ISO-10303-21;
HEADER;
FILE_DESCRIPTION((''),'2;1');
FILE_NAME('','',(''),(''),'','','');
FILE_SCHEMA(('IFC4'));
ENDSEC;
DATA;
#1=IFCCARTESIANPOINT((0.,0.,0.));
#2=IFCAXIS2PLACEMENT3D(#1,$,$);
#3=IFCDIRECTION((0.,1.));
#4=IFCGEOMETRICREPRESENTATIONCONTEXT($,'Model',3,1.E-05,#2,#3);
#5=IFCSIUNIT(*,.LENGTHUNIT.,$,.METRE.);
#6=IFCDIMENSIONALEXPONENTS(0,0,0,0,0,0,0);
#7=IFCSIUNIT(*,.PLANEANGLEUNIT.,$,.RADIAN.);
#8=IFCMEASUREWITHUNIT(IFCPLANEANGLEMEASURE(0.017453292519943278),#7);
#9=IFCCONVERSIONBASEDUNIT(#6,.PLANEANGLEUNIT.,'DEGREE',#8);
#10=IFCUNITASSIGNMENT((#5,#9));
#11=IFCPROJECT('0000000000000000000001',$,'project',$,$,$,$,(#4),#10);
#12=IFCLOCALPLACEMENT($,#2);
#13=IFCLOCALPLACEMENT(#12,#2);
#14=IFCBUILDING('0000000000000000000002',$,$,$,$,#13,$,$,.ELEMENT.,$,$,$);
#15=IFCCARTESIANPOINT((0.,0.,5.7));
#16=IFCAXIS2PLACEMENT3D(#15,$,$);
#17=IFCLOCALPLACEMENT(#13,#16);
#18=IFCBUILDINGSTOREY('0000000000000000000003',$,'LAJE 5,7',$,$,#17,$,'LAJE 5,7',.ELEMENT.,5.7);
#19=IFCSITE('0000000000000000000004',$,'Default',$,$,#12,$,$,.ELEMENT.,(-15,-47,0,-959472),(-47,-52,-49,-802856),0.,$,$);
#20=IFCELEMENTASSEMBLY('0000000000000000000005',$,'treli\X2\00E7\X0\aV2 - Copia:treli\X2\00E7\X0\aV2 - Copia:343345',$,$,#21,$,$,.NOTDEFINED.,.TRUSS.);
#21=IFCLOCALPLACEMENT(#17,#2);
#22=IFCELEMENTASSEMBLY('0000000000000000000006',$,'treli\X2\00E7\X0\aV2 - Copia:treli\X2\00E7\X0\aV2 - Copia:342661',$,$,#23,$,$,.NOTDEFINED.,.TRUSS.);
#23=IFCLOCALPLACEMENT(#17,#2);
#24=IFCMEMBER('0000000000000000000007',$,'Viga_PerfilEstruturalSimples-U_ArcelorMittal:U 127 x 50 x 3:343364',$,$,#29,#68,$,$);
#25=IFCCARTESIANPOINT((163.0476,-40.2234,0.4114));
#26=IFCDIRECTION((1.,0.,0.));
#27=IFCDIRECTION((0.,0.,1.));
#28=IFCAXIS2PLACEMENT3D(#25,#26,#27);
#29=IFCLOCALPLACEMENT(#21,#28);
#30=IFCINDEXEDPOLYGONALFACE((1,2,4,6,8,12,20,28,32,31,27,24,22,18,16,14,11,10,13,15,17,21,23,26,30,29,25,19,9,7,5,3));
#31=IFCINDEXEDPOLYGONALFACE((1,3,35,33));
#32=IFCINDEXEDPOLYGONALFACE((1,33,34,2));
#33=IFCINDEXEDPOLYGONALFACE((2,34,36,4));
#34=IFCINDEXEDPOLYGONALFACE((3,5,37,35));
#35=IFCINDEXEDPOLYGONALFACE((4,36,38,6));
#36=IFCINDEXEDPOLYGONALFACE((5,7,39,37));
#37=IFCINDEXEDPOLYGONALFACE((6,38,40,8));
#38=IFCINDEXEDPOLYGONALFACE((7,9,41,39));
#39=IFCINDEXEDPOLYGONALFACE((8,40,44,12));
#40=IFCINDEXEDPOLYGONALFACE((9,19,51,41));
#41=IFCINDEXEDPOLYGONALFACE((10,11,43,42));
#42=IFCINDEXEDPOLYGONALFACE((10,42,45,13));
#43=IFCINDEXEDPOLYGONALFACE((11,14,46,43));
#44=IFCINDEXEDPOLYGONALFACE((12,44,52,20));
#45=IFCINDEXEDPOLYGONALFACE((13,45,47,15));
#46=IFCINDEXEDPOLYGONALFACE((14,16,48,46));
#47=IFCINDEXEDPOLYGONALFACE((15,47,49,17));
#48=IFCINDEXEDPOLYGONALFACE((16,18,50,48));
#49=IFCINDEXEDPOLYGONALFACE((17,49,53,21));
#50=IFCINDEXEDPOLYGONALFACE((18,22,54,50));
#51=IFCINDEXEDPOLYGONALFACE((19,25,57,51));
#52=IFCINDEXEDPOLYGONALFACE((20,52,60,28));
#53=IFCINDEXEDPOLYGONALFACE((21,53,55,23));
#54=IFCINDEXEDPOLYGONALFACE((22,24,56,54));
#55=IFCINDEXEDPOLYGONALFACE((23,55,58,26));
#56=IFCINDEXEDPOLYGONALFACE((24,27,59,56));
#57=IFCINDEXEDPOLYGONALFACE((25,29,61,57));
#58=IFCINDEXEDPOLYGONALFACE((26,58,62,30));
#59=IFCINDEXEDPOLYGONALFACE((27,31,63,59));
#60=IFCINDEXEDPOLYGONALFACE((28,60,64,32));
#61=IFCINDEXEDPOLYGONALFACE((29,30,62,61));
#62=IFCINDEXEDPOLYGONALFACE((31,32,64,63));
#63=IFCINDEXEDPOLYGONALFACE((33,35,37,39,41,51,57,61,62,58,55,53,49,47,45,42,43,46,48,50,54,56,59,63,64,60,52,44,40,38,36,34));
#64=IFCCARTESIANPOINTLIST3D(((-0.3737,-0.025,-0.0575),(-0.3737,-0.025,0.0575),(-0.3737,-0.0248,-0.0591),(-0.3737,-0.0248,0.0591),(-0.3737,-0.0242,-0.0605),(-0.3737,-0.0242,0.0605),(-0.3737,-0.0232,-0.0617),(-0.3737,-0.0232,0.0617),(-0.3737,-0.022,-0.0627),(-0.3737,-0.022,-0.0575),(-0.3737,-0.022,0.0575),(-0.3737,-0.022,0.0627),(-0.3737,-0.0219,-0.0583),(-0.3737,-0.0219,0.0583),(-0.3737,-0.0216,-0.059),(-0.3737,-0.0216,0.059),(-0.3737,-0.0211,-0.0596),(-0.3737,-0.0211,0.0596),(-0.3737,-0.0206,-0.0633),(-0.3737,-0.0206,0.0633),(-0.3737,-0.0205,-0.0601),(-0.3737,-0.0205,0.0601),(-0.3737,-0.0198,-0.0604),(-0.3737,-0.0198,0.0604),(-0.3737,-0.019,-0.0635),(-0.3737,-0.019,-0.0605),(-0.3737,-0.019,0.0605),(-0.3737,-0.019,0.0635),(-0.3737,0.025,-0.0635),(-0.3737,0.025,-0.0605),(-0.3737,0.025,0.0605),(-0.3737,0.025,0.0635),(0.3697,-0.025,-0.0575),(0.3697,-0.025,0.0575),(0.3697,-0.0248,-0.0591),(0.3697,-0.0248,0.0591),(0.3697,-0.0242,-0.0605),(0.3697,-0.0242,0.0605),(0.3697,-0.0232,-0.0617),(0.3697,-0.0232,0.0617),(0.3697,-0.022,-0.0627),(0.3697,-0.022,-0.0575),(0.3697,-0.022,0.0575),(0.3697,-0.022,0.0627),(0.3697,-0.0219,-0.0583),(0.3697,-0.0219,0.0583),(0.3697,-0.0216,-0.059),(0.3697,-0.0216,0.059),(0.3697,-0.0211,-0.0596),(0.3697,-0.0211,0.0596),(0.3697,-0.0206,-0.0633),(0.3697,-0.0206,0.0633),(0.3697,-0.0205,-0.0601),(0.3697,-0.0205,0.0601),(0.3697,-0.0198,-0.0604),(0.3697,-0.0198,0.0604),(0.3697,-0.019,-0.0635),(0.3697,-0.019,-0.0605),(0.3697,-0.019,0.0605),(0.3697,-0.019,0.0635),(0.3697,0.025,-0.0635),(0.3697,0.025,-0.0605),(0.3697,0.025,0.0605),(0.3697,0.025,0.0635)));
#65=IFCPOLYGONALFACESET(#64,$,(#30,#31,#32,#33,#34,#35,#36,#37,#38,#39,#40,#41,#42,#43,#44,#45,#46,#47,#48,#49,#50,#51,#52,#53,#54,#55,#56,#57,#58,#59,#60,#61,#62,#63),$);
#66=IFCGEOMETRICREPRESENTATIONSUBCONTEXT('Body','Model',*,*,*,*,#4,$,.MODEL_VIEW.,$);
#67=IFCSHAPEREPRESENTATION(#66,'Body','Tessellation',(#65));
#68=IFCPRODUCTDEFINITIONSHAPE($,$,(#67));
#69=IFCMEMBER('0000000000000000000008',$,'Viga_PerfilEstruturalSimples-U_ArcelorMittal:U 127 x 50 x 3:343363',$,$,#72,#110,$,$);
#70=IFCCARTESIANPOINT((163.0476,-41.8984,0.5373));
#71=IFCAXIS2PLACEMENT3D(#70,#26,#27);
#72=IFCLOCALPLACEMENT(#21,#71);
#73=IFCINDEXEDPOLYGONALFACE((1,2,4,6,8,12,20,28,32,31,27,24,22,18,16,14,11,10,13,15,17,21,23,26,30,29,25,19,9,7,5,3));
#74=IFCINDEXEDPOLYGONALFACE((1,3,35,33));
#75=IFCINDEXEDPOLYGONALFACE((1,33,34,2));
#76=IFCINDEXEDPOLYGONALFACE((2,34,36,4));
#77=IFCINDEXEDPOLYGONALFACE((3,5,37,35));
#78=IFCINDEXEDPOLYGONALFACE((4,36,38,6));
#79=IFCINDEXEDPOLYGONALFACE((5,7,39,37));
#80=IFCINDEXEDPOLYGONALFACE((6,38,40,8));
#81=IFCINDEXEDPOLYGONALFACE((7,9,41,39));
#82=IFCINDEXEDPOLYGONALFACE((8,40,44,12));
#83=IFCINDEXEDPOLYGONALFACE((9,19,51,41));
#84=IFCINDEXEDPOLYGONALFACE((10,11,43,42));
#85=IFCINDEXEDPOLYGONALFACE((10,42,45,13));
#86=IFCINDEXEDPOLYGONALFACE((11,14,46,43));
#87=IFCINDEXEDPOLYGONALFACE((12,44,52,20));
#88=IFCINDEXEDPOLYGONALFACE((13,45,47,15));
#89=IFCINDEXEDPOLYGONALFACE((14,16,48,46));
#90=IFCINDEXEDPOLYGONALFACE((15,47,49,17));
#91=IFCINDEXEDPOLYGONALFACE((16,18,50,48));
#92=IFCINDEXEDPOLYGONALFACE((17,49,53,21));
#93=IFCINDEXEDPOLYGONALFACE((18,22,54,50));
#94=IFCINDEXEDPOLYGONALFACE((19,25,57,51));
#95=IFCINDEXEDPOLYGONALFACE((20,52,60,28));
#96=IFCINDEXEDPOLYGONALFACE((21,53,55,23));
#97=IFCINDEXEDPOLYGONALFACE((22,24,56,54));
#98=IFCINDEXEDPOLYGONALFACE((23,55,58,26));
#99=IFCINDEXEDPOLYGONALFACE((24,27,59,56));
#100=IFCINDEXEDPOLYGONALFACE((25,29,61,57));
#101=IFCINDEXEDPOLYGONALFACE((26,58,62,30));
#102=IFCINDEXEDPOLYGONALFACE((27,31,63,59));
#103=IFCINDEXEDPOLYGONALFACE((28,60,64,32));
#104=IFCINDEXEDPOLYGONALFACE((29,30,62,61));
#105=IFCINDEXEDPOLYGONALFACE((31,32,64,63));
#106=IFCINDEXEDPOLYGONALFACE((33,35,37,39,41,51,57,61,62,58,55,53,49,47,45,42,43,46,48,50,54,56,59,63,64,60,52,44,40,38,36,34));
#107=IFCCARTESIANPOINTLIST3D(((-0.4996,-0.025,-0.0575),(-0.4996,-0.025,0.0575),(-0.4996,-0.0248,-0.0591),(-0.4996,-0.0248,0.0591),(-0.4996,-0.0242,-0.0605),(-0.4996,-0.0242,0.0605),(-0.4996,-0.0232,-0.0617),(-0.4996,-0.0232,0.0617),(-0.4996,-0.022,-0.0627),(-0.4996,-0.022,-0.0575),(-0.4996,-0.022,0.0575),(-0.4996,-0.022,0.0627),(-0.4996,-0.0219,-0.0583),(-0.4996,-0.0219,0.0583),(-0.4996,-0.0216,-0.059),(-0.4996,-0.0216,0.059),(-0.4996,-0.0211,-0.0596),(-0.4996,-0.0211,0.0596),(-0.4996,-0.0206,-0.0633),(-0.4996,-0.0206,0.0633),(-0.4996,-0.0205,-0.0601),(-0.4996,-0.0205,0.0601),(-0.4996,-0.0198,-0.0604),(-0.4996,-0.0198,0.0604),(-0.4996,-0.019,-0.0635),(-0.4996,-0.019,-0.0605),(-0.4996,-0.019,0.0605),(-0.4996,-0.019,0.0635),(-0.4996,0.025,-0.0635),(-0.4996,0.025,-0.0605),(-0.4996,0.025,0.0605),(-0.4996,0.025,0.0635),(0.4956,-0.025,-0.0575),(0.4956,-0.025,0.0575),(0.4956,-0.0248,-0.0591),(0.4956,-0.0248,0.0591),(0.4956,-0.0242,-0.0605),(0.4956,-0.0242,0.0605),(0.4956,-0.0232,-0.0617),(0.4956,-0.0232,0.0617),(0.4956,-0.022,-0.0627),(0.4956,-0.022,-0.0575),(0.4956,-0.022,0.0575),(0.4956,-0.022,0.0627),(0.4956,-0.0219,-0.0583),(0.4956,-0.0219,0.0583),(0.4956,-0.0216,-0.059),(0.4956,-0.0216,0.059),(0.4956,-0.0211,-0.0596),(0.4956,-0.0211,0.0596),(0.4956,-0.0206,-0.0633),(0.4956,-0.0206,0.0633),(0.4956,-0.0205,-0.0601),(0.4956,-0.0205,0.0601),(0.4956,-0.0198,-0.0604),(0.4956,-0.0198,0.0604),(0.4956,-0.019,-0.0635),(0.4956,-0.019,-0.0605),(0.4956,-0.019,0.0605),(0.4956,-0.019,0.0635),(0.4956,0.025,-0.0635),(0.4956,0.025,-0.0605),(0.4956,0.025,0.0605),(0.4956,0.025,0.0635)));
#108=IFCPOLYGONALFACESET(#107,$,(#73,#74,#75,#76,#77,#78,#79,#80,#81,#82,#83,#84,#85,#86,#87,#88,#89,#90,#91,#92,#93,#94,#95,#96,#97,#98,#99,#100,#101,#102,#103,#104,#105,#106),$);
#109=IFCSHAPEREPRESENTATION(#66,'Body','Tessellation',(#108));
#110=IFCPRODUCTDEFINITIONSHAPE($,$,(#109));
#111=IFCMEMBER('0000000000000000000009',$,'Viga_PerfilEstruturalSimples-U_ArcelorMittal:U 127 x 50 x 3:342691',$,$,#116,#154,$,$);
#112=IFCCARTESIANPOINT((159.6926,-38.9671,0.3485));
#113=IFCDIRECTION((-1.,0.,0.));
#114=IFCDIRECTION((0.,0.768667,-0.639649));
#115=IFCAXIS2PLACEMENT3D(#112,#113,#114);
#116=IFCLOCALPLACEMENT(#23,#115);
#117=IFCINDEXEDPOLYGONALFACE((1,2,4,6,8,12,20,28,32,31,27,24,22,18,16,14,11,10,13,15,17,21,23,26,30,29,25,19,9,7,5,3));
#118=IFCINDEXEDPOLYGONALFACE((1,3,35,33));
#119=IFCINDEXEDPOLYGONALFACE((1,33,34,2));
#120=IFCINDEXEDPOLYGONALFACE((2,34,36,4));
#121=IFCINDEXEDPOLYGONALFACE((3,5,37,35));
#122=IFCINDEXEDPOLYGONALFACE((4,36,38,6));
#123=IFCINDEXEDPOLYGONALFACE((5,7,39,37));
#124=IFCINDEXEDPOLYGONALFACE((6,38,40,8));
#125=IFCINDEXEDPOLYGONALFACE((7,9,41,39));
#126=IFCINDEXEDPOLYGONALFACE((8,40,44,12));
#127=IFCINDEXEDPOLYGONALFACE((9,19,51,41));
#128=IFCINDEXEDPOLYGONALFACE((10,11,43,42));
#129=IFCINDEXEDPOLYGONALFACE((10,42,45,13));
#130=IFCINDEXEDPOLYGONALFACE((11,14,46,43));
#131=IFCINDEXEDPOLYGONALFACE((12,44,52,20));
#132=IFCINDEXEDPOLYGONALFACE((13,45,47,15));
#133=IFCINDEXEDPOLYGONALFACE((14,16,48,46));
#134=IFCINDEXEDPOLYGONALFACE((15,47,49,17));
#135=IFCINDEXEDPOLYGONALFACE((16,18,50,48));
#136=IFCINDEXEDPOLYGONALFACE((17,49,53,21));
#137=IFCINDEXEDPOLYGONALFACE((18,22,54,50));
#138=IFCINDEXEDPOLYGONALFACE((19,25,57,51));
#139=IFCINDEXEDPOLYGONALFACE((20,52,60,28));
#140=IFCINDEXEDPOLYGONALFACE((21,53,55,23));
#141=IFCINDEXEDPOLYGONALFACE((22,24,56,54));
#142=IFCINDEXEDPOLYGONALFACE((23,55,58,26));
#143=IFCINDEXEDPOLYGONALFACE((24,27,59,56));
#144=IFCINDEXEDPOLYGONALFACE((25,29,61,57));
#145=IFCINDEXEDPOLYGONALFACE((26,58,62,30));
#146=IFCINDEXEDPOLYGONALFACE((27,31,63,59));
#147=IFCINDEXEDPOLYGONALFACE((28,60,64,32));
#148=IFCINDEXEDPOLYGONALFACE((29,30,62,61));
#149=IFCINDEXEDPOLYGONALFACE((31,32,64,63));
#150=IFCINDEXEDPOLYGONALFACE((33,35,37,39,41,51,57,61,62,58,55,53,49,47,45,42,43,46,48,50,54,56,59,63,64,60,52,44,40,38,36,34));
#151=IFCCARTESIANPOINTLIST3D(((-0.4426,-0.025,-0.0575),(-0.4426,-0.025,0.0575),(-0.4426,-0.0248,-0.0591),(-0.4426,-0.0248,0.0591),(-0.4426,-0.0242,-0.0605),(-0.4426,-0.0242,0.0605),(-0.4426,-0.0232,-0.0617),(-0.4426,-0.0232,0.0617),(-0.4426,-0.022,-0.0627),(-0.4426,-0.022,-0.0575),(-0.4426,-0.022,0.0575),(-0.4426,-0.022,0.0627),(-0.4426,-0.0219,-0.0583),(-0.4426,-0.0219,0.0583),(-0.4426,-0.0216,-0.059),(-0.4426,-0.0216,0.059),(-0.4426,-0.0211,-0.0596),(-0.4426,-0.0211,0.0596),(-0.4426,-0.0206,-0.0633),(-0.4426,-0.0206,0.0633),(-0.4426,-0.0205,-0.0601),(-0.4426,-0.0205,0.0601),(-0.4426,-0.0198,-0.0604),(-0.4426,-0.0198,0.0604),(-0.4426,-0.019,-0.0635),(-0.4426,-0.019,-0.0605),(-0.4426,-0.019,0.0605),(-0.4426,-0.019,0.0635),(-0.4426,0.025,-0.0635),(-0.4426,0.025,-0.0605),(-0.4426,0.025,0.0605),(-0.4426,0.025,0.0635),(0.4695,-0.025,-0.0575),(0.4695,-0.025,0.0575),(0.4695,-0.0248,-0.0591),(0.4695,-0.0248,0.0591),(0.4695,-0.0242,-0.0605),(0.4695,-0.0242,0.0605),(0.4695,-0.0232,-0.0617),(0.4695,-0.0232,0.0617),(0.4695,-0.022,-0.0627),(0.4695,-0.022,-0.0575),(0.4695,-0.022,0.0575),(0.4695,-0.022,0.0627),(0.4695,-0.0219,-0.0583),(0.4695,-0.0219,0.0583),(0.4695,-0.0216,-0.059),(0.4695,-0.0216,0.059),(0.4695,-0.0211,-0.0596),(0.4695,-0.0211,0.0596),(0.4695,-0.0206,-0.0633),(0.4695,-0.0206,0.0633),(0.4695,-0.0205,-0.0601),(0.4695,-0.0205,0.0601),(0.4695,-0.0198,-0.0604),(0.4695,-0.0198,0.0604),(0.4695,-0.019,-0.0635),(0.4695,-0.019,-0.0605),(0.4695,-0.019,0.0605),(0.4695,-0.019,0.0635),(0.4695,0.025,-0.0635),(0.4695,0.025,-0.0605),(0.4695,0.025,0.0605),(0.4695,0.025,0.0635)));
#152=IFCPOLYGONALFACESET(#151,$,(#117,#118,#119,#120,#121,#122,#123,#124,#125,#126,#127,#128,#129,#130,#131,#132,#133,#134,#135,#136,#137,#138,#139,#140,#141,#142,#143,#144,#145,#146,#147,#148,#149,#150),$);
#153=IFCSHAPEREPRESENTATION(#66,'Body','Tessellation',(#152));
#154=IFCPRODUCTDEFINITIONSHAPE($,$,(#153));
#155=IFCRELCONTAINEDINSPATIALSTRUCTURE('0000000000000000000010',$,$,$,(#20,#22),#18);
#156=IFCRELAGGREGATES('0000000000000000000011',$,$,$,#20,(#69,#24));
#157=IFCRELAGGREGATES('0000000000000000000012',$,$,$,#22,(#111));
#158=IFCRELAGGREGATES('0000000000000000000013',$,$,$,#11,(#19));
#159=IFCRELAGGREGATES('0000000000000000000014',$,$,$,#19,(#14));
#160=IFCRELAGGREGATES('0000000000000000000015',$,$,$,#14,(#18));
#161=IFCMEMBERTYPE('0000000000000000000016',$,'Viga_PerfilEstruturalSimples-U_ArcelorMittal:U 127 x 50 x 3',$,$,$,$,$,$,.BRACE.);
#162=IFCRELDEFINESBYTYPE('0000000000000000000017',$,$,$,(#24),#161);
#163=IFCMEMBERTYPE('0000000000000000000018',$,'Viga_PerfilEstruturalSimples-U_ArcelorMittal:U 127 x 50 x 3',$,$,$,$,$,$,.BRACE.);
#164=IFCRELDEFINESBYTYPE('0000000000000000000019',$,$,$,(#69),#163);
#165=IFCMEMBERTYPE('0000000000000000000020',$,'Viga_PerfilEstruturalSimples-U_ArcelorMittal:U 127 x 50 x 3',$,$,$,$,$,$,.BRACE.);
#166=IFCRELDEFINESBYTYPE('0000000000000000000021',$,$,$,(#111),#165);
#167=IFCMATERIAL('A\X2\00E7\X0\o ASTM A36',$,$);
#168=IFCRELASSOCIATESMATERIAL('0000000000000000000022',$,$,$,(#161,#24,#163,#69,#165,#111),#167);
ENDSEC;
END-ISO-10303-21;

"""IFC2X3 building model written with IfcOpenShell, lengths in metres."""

from ifc_helpers import new_model, entity, si_unit, converted_unit, direction, frame, frame_2d, origin, place, context, subcontext, project, spatial, polyline, circle_curve, parameter, trimmed, segment, composite_curve, outline, extrude, source, transform, mapped, material, type_object, type_shapes, element, aggregate, save


model = new_model("IFC2X3")

# Units and contexts
model_context = context("Model", 3, precision=1e-05, world=origin(), true_north=direction((0.0, 1.0)))
body_context = subcontext(model_context, "Body", "Model", "MODEL_VIEW")
ifc_project = project(units=[si_unit("LENGTHUNIT", "METRE"), converted_unit("PLANEANGLEUNIT", "DEGREE", entity("IfcPlaneAngleMeasure", 0.017453292519943278), si_unit("PLANEANGLEUNIT", "RADIAN"), dimensions=[0, 0, 0, 0, 0, 0, 0])], contexts=[model_context])

# Site, building, storey
site_placement = place(None, origin())
site = spatial("IfcSite", under=ifc_project, at=site_placement, Name="Default", CompositionType="ELEMENT", RefLatitude=(-15, -47, 0, -959472), RefLongitude=(-47, -52, -49, -802856), RefElevation=0.0)
building_placement = place(site_placement, origin())
building = spatial("IfcBuilding", under=site, at=building_placement, CompositionType="ELEMENT")
storey_placement = place(building_placement, frame((0.0, 0.0, 5.7)))
storey = spatial("IfcBuildingStorey", under=building, at=storey_placement, Name="LAJE 5,7", LongName="LAJE 5,7", CompositionType="ELEMENT", Elevation=5.7)

# Element assemblies
assembly_1_placement = place(storey_placement, origin())
assembly_1 = element("IfcElementAssembly", 1, at=assembly_1_placement, inside=storey, Name="treliçaV2 - Copia:treliçaV2 - Copia:343345", AssemblyPlace="NOTDEFINED", PredefinedType="TRUSS")
ifc_material = material(Name="Aço ASTM A36")
assembly_2_placement = place(storey_placement, origin())
assembly_2 = element("IfcElementAssembly", 2, at=assembly_2_placement, inside=storey, Name="treliçaV2 - Copia:treliçaV2 - Copia:342661", AssemblyPlace="NOTDEFINED", PredefinedType="TRUSS")

# Members
member_type_1 = type_object("IfcMemberType", Name="Viga_PerfilEstruturalSimples-U_ArcelorMittal:U 127 x 50 x 3", PredefinedType="BRACE", material=ifc_material)
shared_shape_1 = source(origin(), body_context, "Body", "SweptSolid", [
    extrude(outline(composite_curve([segment(polyline([(-0.0575, -0.0192), (0.0575, -0.0192)]), True, "CONTINUOUS"), segment(trimmed(circle_curve(frame_2d((0.0575, -0.0132), x_axis=(0.0, 1.0)), 0.006), [parameter(180.0)], [parameter(270.0)], True, "PARAMETER"), True, "CONTINUOUS"), segment(polyline([(0.0635, -0.0132), (0.0635, 0.0308)]), True, "CONTINUOUS"), segment(polyline([(0.0635, 0.0308), (0.0605, 0.0308)]), True, "CONTINUOUS"), segment(polyline([(0.0605, 0.0308), (0.0605, -0.0132)]), True, "CONTINUOUS"), segment(trimmed(circle_curve(frame_2d((0.0575, -0.0132), x_axis=(0.0, 1.0)), 0.003), [parameter(180.0)], [parameter(270.0)], True, "PARAMETER"), False, "CONTINUOUS"), segment(polyline([(0.0575, -0.0162), (-0.0575, -0.0162)]), True, "CONTINUOUS"), segment(trimmed(circle_curve(frame_2d((-0.0575, -0.0132), x_axis=(0.0, 1.0)), 0.003), [parameter(90.0)], [parameter(180.0)], True, "PARAMETER"), False, "CONTINUOUS"), segment(polyline([(-0.0605, -0.0132), (-0.0605, 0.0308)]), True, "CONTINUOUS"), segment(polyline([(-0.0605, 0.0308), (-0.0635, 0.0308)]), True, "CONTINUOUS"), segment(polyline([(-0.0635, 0.0308), (-0.0635, -0.0132)]), True, "CONTINUOUS"), segment(trimmed(circle_curve(frame_2d((-0.0575, -0.0132), x_axis=(0.0, 1.0)), 0.006), [parameter(90.0)], [parameter(180.0)], True, "PARAMETER"), True, "CONTINUOUS")], self_intersect=False)), frame((-0.3737, -0.0058, 0.0), z_axis=(1.0, 0.0, 0.0), x_axis=(0.0, 0.0, -1.0)), (0.0, 0.0, 1.0), 0.7434),
])
type_shapes(member_type_1, [shared_shape_1])
member_1_placement = place(assembly_1_placement, frame((163.0476, -40.2234, 0.4114), z_axis=(1.0, 0.0, 0.0), x_axis=(0.0, 0.0, 1.0)))
member_1 = element("IfcMember", 3, at=member_1_placement, type_object=member_type_1, material=ifc_material, Name="Viga_PerfilEstruturalSimples-U_ArcelorMittal:U 127 x 50 x 3:343364", context=body_context, shape_type="MappedRepresentation", body=[
    mapped(shared_shape_1, transform((0.0, 0.0, 0.0), scale=1.0)),
])
member_type_2 = type_object("IfcMemberType", Name="Viga_PerfilEstruturalSimples-U_ArcelorMittal:U 127 x 50 x 3", PredefinedType="BRACE", material=ifc_material)
shared_shape_2 = source(origin(), body_context, "Body", "SweptSolid", [
    extrude(outline(composite_curve([segment(polyline([(-0.0575, -0.0192), (0.0575, -0.0192)]), True, "CONTINUOUS"), segment(trimmed(circle_curve(frame_2d((0.0575, -0.0132), x_axis=(0.0, 1.0)), 0.006), [parameter(180.0)], [parameter(270.0)], True, "PARAMETER"), True, "CONTINUOUS"), segment(polyline([(0.0635, -0.0132), (0.0635, 0.0308)]), True, "CONTINUOUS"), segment(polyline([(0.0635, 0.0308), (0.0605, 0.0308)]), True, "CONTINUOUS"), segment(polyline([(0.0605, 0.0308), (0.0605, -0.0132)]), True, "CONTINUOUS"), segment(trimmed(circle_curve(frame_2d((0.0575, -0.0132), x_axis=(0.0, 1.0)), 0.003), [parameter(180.0)], [parameter(270.0)], True, "PARAMETER"), False, "CONTINUOUS"), segment(polyline([(0.0575, -0.0162), (-0.0575, -0.0162)]), True, "CONTINUOUS"), segment(trimmed(circle_curve(frame_2d((-0.0575, -0.0132), x_axis=(0.0, 1.0)), 0.003), [parameter(90.0)], [parameter(180.0)], True, "PARAMETER"), False, "CONTINUOUS"), segment(polyline([(-0.0605, -0.0132), (-0.0605, 0.0308)]), True, "CONTINUOUS"), segment(polyline([(-0.0605, 0.0308), (-0.0635, 0.0308)]), True, "CONTINUOUS"), segment(polyline([(-0.0635, 0.0308), (-0.0635, -0.0132)]), True, "CONTINUOUS"), segment(trimmed(circle_curve(frame_2d((-0.0575, -0.0132), x_axis=(0.0, 1.0)), 0.006), [parameter(90.0)], [parameter(180.0)], True, "PARAMETER"), True, "CONTINUOUS")], self_intersect=False)), frame((-0.4996, -0.0058, 0.0), z_axis=(1.0, 0.0, 0.0), x_axis=(0.0, 0.0, -1.0)), (0.0, 0.0, 1.0), 0.9952),
])
type_shapes(member_type_2, [shared_shape_2])
member_2_placement = place(assembly_1_placement, frame((163.0476, -41.8984, 0.5373), z_axis=(1.0, 0.0, 0.0), x_axis=(0.0, 0.0, 1.0)))
member_2 = element("IfcMember", 4, at=member_2_placement, type_object=member_type_2, material=ifc_material, Name="Viga_PerfilEstruturalSimples-U_ArcelorMittal:U 127 x 50 x 3:343363", context=body_context, shape_type="MappedRepresentation", body=[
    mapped(shared_shape_2, transform((0.0, 0.0, 0.0), scale=1.0)),
])
aggregate(assembly_1, [member_2, member_1])
member_type_3 = type_object("IfcMemberType", Name="Viga_PerfilEstruturalSimples-U_ArcelorMittal:U 127 x 50 x 3", PredefinedType="BRACE", material=ifc_material)
shared_shape_3 = source(origin(), body_context, "Body", "SweptSolid", [
    extrude(outline(composite_curve([segment(polyline([(-0.0575, -0.0192), (0.0575, -0.0192)]), True, "CONTINUOUS"), segment(trimmed(circle_curve(frame_2d((0.0575, -0.0132), x_axis=(0.0, 1.0)), 0.006), [parameter(180.0)], [parameter(270.0)], True, "PARAMETER"), True, "CONTINUOUS"), segment(polyline([(0.0635, -0.0132), (0.0635, 0.0308)]), True, "CONTINUOUS"), segment(polyline([(0.0635, 0.0308), (0.0605, 0.0308)]), True, "CONTINUOUS"), segment(polyline([(0.0605, 0.0308), (0.0605, -0.0132)]), True, "CONTINUOUS"), segment(trimmed(circle_curve(frame_2d((0.0575, -0.0132), x_axis=(0.0, 1.0)), 0.003), [parameter(180.0)], [parameter(270.0)], True, "PARAMETER"), False, "CONTINUOUS"), segment(polyline([(0.0575, -0.0162), (-0.0575, -0.0162)]), True, "CONTINUOUS"), segment(trimmed(circle_curve(frame_2d((-0.0575, -0.0132), x_axis=(0.0, 1.0)), 0.003), [parameter(90.0)], [parameter(180.0)], True, "PARAMETER"), False, "CONTINUOUS"), segment(polyline([(-0.0605, -0.0132), (-0.0605, 0.0308)]), True, "CONTINUOUS"), segment(polyline([(-0.0605, 0.0308), (-0.0635, 0.0308)]), True, "CONTINUOUS"), segment(polyline([(-0.0635, 0.0308), (-0.0635, -0.0132)]), True, "CONTINUOUS"), segment(trimmed(circle_curve(frame_2d((-0.0575, -0.0132), x_axis=(0.0, 1.0)), 0.006), [parameter(90.0)], [parameter(180.0)], True, "PARAMETER"), True, "CONTINUOUS")], self_intersect=False)), frame((-0.4426, -0.0058, 0.0), z_axis=(1.0, 0.0, 0.0), x_axis=(0.0, 0.0, -1.0)), (0.0, 0.0, 1.0), 0.9121),
])
type_shapes(member_type_3, [shared_shape_3])
member_3_placement = place(assembly_2_placement, frame((159.6926, -38.9671, 0.3485), z_axis=(-1.0, 0.0, 0.0), x_axis=(0.0, 0.768667, -0.639649)))
member_3 = element("IfcMember", 5, at=member_3_placement, type_object=member_type_3, material=ifc_material, Name="Viga_PerfilEstruturalSimples-U_ArcelorMittal:U 127 x 50 x 3:342691", context=body_context, shape_type="MappedRepresentation", body=[
    mapped(shared_shape_3, transform((0.0, 0.0, 0.0), scale=1.0)),
])
aggregate(assembly_2, [member_3])

save(model, "model.ifc")
